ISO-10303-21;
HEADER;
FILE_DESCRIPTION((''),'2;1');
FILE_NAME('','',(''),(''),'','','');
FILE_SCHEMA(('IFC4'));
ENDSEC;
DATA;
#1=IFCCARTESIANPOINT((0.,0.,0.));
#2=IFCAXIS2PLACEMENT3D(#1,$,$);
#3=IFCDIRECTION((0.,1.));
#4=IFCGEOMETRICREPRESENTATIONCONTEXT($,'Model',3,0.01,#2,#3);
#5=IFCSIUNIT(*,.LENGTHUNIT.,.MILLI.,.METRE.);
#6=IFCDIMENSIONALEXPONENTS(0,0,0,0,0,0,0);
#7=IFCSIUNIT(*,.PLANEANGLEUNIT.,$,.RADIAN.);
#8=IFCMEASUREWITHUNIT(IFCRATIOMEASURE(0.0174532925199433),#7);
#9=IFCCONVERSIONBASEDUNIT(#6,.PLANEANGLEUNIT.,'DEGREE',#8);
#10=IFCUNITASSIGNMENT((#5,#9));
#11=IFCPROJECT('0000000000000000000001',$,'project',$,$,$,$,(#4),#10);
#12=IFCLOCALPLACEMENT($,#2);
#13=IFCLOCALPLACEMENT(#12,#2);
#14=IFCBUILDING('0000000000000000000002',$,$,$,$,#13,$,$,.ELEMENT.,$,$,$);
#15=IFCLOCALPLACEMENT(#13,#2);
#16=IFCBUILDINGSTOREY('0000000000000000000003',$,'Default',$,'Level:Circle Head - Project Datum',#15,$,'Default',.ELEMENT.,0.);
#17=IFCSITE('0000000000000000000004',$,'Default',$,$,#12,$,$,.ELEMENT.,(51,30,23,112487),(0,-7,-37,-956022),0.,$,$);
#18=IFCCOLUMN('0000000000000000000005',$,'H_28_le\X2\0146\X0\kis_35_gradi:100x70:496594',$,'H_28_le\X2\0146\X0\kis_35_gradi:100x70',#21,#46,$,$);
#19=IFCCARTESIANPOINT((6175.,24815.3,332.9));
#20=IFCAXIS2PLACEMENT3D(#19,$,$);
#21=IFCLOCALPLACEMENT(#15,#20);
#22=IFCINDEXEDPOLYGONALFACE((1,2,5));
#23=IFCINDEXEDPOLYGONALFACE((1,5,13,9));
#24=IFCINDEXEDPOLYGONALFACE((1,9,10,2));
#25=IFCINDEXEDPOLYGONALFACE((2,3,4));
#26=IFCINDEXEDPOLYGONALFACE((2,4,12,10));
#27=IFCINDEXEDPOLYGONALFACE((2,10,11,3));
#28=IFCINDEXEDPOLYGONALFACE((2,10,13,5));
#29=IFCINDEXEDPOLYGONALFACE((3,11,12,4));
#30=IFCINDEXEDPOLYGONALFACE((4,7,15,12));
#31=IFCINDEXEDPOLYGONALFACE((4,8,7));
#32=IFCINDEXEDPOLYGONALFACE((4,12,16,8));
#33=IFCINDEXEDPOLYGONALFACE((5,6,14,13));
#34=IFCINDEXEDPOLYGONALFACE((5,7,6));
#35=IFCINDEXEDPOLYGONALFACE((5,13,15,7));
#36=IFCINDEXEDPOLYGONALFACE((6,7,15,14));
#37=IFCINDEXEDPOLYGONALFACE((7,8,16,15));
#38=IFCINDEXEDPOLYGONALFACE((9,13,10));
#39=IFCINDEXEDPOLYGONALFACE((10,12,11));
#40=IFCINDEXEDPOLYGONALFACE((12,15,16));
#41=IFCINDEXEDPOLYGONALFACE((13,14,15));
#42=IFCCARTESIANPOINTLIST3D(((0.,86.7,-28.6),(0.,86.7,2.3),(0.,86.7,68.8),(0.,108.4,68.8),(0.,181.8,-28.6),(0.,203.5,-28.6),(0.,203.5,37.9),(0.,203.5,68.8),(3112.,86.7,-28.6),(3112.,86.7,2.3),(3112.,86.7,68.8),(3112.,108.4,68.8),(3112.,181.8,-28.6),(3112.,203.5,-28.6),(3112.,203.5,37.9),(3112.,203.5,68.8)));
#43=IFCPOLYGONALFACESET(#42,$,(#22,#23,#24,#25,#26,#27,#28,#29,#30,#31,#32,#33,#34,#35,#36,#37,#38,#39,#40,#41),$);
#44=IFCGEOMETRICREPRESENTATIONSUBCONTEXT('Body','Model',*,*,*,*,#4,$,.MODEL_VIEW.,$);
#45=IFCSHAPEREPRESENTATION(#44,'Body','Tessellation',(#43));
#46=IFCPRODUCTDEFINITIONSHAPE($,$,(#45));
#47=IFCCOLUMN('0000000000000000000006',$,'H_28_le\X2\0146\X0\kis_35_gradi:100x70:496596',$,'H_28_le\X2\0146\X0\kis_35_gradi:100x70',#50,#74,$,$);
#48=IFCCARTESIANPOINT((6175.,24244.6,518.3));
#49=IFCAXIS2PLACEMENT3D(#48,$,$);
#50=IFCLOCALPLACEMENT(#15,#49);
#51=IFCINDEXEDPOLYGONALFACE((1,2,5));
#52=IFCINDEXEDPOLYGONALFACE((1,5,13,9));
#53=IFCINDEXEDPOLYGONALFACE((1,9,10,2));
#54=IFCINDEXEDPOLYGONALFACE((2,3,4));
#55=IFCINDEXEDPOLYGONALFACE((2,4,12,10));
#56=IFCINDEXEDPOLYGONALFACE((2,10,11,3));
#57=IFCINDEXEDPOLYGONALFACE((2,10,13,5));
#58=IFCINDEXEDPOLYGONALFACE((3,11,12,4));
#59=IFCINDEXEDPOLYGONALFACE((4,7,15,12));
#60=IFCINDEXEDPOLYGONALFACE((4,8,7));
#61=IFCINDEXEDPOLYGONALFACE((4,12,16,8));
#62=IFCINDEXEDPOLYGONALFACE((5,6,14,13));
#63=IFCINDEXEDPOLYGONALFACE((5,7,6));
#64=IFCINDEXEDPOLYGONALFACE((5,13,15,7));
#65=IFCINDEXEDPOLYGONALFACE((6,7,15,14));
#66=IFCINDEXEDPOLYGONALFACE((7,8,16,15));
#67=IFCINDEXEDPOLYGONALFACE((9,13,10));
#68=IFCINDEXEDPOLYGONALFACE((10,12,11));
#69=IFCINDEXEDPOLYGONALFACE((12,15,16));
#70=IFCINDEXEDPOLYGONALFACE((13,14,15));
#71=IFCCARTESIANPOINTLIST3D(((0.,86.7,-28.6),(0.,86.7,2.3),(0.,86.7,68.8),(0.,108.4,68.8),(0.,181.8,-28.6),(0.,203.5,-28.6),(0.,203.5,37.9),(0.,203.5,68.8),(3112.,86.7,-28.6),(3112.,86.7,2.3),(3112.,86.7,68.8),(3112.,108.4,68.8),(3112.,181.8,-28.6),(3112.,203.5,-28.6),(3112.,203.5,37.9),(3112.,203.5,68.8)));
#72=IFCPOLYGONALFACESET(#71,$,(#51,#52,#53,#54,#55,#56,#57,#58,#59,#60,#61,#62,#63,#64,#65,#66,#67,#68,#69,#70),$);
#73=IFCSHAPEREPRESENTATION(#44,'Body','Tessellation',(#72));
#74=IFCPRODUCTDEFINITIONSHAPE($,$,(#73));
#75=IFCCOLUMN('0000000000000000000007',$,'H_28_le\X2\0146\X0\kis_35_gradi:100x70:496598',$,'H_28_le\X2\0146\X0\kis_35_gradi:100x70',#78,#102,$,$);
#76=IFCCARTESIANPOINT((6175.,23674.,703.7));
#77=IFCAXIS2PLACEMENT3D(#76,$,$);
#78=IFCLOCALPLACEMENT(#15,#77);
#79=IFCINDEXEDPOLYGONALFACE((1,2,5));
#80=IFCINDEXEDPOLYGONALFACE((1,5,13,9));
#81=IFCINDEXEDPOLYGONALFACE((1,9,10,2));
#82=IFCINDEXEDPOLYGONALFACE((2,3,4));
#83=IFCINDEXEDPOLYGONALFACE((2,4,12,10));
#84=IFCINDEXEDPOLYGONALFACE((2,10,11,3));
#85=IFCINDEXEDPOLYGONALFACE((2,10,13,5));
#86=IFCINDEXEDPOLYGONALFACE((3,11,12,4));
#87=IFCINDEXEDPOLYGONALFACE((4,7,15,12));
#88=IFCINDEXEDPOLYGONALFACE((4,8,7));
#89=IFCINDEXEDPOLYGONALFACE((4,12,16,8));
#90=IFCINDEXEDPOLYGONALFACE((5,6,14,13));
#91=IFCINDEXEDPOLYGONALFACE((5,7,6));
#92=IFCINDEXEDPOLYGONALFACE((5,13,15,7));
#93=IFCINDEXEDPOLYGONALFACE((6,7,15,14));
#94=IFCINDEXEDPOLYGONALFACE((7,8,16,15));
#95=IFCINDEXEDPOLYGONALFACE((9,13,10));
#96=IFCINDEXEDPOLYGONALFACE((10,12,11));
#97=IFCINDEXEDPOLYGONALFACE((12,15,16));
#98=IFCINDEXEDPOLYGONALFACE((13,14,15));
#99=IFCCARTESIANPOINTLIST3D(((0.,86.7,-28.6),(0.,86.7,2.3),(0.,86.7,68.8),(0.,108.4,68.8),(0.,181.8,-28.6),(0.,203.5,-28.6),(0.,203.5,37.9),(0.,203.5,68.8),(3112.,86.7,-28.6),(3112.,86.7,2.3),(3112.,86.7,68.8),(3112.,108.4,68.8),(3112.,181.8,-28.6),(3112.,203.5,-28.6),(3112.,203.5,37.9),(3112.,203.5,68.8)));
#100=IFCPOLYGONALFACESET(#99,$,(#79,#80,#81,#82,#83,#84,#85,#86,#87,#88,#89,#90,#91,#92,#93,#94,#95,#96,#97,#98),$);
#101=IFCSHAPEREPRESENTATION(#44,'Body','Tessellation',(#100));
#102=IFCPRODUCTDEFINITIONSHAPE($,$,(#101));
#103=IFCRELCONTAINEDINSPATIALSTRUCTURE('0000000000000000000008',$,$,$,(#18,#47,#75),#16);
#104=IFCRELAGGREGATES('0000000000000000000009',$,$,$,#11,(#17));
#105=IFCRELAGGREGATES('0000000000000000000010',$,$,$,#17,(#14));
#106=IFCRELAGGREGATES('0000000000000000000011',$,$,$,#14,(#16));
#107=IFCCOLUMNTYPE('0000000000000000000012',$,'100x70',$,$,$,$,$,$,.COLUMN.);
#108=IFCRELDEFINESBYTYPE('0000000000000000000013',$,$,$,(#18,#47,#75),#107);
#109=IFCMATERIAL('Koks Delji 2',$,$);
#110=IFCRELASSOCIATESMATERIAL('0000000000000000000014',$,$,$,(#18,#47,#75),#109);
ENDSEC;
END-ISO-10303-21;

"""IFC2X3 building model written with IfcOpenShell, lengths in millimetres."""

from ifc_helpers import new_model, entity, si_unit, converted_unit, direction, frame, frame_2d, origin, origin_2d_with_axis, place, context, subcontext, project, spatial, rectangle, extrude, boolean, source, transform, mapped, material, type_object, type_shapes, element, save


model = new_model("IFC2X3")

# Units and contexts
model_context = context("Model", 3, precision=0.01, world=origin(), true_north=direction((0.0, 1.0)))
body_context = subcontext(model_context, "Body", "Model", "MODEL_VIEW")
ifc_project = project(units=[si_unit("LENGTHUNIT", "METRE", prefix="MILLI"), converted_unit("PLANEANGLEUNIT", "DEGREE", entity("IfcRatioMeasure", 0.0174532925199433), si_unit("PLANEANGLEUNIT", "RADIAN"), dimensions=[0, 0, 0, 0, 0, 0, 0])], contexts=[model_context])

# Site, building, storey
site_placement = place(None, origin())
site = spatial("IfcSite", under=ifc_project, at=site_placement, Name="Default", CompositionType="ELEMENT", RefLatitude=(51, 30, 23, 112487), RefLongitude=(0, -7, -37, -956022), RefElevation=0.0)
building_placement = place(site_placement, origin())
building = spatial("IfcBuilding", under=site, at=building_placement, CompositionType="ELEMENT")
storey_placement = place(building_placement, origin())
storey = spatial("IfcBuildingStorey", under=building, at=storey_placement, Name="Default", ObjectType="Level:Circle Head - Project Datum", LongName="Default", CompositionType="ELEMENT", Elevation=0.0)

# Columns
ifc_material_1 = material(Name="Koks Delji 2")
column_type = type_object("IfcColumnType", Name="100x70", PredefinedType="COLUMN")
shared_shape_1 = source(origin(), body_context, "Body", "CSG", [
    boolean("DIFFERENCE", extrude(rectangle(XDim=3112.0, YDim=116.7, at=origin_2d_with_axis()), frame((1556.0, 145.1, -28.6)), (0.0, 0.0, 1.0), 97.5), extrude(rectangle(XDim=70.0, YDim=100.0, at=frame_2d((0.0, 0.0), x_axis=(0.0, 1.0))), frame((3112.0, 145.1, 20.1), z_axis=(1.0, 0.0, 0.0), x_axis=(0.0, 0.951057, -0.309017)), (0.0, 0.0, -1.0), 3112.0)),
])
type_shapes(column_type, [shared_shape_1])
for number, where, name in (
    (1, (6175.0, 24815.3, 332.9), "H_28_leņkis_35_gradi:100x70:496594"),
    (2, (6175.0, 24244.6, 518.3), "H_28_leņkis_35_gradi:100x70:496596"),
    (3, (6175.0, 23674.0, 703.7), "H_28_leņkis_35_gradi:100x70:496598"),
):
    element("IfcColumn", number, at=place(storey_placement, frame(where)), inside=storey, type_object=column_type, material=ifc_material_1, Name=name, ObjectType="H_28_leņkis_35_gradi:100x70", context=body_context, shape_type="MappedRepresentation", body=[
        mapped(shared_shape_1, transform((0.0, 0.0, 0.0), scale=1.0)),
    ])

save(model, "model.ifc")
